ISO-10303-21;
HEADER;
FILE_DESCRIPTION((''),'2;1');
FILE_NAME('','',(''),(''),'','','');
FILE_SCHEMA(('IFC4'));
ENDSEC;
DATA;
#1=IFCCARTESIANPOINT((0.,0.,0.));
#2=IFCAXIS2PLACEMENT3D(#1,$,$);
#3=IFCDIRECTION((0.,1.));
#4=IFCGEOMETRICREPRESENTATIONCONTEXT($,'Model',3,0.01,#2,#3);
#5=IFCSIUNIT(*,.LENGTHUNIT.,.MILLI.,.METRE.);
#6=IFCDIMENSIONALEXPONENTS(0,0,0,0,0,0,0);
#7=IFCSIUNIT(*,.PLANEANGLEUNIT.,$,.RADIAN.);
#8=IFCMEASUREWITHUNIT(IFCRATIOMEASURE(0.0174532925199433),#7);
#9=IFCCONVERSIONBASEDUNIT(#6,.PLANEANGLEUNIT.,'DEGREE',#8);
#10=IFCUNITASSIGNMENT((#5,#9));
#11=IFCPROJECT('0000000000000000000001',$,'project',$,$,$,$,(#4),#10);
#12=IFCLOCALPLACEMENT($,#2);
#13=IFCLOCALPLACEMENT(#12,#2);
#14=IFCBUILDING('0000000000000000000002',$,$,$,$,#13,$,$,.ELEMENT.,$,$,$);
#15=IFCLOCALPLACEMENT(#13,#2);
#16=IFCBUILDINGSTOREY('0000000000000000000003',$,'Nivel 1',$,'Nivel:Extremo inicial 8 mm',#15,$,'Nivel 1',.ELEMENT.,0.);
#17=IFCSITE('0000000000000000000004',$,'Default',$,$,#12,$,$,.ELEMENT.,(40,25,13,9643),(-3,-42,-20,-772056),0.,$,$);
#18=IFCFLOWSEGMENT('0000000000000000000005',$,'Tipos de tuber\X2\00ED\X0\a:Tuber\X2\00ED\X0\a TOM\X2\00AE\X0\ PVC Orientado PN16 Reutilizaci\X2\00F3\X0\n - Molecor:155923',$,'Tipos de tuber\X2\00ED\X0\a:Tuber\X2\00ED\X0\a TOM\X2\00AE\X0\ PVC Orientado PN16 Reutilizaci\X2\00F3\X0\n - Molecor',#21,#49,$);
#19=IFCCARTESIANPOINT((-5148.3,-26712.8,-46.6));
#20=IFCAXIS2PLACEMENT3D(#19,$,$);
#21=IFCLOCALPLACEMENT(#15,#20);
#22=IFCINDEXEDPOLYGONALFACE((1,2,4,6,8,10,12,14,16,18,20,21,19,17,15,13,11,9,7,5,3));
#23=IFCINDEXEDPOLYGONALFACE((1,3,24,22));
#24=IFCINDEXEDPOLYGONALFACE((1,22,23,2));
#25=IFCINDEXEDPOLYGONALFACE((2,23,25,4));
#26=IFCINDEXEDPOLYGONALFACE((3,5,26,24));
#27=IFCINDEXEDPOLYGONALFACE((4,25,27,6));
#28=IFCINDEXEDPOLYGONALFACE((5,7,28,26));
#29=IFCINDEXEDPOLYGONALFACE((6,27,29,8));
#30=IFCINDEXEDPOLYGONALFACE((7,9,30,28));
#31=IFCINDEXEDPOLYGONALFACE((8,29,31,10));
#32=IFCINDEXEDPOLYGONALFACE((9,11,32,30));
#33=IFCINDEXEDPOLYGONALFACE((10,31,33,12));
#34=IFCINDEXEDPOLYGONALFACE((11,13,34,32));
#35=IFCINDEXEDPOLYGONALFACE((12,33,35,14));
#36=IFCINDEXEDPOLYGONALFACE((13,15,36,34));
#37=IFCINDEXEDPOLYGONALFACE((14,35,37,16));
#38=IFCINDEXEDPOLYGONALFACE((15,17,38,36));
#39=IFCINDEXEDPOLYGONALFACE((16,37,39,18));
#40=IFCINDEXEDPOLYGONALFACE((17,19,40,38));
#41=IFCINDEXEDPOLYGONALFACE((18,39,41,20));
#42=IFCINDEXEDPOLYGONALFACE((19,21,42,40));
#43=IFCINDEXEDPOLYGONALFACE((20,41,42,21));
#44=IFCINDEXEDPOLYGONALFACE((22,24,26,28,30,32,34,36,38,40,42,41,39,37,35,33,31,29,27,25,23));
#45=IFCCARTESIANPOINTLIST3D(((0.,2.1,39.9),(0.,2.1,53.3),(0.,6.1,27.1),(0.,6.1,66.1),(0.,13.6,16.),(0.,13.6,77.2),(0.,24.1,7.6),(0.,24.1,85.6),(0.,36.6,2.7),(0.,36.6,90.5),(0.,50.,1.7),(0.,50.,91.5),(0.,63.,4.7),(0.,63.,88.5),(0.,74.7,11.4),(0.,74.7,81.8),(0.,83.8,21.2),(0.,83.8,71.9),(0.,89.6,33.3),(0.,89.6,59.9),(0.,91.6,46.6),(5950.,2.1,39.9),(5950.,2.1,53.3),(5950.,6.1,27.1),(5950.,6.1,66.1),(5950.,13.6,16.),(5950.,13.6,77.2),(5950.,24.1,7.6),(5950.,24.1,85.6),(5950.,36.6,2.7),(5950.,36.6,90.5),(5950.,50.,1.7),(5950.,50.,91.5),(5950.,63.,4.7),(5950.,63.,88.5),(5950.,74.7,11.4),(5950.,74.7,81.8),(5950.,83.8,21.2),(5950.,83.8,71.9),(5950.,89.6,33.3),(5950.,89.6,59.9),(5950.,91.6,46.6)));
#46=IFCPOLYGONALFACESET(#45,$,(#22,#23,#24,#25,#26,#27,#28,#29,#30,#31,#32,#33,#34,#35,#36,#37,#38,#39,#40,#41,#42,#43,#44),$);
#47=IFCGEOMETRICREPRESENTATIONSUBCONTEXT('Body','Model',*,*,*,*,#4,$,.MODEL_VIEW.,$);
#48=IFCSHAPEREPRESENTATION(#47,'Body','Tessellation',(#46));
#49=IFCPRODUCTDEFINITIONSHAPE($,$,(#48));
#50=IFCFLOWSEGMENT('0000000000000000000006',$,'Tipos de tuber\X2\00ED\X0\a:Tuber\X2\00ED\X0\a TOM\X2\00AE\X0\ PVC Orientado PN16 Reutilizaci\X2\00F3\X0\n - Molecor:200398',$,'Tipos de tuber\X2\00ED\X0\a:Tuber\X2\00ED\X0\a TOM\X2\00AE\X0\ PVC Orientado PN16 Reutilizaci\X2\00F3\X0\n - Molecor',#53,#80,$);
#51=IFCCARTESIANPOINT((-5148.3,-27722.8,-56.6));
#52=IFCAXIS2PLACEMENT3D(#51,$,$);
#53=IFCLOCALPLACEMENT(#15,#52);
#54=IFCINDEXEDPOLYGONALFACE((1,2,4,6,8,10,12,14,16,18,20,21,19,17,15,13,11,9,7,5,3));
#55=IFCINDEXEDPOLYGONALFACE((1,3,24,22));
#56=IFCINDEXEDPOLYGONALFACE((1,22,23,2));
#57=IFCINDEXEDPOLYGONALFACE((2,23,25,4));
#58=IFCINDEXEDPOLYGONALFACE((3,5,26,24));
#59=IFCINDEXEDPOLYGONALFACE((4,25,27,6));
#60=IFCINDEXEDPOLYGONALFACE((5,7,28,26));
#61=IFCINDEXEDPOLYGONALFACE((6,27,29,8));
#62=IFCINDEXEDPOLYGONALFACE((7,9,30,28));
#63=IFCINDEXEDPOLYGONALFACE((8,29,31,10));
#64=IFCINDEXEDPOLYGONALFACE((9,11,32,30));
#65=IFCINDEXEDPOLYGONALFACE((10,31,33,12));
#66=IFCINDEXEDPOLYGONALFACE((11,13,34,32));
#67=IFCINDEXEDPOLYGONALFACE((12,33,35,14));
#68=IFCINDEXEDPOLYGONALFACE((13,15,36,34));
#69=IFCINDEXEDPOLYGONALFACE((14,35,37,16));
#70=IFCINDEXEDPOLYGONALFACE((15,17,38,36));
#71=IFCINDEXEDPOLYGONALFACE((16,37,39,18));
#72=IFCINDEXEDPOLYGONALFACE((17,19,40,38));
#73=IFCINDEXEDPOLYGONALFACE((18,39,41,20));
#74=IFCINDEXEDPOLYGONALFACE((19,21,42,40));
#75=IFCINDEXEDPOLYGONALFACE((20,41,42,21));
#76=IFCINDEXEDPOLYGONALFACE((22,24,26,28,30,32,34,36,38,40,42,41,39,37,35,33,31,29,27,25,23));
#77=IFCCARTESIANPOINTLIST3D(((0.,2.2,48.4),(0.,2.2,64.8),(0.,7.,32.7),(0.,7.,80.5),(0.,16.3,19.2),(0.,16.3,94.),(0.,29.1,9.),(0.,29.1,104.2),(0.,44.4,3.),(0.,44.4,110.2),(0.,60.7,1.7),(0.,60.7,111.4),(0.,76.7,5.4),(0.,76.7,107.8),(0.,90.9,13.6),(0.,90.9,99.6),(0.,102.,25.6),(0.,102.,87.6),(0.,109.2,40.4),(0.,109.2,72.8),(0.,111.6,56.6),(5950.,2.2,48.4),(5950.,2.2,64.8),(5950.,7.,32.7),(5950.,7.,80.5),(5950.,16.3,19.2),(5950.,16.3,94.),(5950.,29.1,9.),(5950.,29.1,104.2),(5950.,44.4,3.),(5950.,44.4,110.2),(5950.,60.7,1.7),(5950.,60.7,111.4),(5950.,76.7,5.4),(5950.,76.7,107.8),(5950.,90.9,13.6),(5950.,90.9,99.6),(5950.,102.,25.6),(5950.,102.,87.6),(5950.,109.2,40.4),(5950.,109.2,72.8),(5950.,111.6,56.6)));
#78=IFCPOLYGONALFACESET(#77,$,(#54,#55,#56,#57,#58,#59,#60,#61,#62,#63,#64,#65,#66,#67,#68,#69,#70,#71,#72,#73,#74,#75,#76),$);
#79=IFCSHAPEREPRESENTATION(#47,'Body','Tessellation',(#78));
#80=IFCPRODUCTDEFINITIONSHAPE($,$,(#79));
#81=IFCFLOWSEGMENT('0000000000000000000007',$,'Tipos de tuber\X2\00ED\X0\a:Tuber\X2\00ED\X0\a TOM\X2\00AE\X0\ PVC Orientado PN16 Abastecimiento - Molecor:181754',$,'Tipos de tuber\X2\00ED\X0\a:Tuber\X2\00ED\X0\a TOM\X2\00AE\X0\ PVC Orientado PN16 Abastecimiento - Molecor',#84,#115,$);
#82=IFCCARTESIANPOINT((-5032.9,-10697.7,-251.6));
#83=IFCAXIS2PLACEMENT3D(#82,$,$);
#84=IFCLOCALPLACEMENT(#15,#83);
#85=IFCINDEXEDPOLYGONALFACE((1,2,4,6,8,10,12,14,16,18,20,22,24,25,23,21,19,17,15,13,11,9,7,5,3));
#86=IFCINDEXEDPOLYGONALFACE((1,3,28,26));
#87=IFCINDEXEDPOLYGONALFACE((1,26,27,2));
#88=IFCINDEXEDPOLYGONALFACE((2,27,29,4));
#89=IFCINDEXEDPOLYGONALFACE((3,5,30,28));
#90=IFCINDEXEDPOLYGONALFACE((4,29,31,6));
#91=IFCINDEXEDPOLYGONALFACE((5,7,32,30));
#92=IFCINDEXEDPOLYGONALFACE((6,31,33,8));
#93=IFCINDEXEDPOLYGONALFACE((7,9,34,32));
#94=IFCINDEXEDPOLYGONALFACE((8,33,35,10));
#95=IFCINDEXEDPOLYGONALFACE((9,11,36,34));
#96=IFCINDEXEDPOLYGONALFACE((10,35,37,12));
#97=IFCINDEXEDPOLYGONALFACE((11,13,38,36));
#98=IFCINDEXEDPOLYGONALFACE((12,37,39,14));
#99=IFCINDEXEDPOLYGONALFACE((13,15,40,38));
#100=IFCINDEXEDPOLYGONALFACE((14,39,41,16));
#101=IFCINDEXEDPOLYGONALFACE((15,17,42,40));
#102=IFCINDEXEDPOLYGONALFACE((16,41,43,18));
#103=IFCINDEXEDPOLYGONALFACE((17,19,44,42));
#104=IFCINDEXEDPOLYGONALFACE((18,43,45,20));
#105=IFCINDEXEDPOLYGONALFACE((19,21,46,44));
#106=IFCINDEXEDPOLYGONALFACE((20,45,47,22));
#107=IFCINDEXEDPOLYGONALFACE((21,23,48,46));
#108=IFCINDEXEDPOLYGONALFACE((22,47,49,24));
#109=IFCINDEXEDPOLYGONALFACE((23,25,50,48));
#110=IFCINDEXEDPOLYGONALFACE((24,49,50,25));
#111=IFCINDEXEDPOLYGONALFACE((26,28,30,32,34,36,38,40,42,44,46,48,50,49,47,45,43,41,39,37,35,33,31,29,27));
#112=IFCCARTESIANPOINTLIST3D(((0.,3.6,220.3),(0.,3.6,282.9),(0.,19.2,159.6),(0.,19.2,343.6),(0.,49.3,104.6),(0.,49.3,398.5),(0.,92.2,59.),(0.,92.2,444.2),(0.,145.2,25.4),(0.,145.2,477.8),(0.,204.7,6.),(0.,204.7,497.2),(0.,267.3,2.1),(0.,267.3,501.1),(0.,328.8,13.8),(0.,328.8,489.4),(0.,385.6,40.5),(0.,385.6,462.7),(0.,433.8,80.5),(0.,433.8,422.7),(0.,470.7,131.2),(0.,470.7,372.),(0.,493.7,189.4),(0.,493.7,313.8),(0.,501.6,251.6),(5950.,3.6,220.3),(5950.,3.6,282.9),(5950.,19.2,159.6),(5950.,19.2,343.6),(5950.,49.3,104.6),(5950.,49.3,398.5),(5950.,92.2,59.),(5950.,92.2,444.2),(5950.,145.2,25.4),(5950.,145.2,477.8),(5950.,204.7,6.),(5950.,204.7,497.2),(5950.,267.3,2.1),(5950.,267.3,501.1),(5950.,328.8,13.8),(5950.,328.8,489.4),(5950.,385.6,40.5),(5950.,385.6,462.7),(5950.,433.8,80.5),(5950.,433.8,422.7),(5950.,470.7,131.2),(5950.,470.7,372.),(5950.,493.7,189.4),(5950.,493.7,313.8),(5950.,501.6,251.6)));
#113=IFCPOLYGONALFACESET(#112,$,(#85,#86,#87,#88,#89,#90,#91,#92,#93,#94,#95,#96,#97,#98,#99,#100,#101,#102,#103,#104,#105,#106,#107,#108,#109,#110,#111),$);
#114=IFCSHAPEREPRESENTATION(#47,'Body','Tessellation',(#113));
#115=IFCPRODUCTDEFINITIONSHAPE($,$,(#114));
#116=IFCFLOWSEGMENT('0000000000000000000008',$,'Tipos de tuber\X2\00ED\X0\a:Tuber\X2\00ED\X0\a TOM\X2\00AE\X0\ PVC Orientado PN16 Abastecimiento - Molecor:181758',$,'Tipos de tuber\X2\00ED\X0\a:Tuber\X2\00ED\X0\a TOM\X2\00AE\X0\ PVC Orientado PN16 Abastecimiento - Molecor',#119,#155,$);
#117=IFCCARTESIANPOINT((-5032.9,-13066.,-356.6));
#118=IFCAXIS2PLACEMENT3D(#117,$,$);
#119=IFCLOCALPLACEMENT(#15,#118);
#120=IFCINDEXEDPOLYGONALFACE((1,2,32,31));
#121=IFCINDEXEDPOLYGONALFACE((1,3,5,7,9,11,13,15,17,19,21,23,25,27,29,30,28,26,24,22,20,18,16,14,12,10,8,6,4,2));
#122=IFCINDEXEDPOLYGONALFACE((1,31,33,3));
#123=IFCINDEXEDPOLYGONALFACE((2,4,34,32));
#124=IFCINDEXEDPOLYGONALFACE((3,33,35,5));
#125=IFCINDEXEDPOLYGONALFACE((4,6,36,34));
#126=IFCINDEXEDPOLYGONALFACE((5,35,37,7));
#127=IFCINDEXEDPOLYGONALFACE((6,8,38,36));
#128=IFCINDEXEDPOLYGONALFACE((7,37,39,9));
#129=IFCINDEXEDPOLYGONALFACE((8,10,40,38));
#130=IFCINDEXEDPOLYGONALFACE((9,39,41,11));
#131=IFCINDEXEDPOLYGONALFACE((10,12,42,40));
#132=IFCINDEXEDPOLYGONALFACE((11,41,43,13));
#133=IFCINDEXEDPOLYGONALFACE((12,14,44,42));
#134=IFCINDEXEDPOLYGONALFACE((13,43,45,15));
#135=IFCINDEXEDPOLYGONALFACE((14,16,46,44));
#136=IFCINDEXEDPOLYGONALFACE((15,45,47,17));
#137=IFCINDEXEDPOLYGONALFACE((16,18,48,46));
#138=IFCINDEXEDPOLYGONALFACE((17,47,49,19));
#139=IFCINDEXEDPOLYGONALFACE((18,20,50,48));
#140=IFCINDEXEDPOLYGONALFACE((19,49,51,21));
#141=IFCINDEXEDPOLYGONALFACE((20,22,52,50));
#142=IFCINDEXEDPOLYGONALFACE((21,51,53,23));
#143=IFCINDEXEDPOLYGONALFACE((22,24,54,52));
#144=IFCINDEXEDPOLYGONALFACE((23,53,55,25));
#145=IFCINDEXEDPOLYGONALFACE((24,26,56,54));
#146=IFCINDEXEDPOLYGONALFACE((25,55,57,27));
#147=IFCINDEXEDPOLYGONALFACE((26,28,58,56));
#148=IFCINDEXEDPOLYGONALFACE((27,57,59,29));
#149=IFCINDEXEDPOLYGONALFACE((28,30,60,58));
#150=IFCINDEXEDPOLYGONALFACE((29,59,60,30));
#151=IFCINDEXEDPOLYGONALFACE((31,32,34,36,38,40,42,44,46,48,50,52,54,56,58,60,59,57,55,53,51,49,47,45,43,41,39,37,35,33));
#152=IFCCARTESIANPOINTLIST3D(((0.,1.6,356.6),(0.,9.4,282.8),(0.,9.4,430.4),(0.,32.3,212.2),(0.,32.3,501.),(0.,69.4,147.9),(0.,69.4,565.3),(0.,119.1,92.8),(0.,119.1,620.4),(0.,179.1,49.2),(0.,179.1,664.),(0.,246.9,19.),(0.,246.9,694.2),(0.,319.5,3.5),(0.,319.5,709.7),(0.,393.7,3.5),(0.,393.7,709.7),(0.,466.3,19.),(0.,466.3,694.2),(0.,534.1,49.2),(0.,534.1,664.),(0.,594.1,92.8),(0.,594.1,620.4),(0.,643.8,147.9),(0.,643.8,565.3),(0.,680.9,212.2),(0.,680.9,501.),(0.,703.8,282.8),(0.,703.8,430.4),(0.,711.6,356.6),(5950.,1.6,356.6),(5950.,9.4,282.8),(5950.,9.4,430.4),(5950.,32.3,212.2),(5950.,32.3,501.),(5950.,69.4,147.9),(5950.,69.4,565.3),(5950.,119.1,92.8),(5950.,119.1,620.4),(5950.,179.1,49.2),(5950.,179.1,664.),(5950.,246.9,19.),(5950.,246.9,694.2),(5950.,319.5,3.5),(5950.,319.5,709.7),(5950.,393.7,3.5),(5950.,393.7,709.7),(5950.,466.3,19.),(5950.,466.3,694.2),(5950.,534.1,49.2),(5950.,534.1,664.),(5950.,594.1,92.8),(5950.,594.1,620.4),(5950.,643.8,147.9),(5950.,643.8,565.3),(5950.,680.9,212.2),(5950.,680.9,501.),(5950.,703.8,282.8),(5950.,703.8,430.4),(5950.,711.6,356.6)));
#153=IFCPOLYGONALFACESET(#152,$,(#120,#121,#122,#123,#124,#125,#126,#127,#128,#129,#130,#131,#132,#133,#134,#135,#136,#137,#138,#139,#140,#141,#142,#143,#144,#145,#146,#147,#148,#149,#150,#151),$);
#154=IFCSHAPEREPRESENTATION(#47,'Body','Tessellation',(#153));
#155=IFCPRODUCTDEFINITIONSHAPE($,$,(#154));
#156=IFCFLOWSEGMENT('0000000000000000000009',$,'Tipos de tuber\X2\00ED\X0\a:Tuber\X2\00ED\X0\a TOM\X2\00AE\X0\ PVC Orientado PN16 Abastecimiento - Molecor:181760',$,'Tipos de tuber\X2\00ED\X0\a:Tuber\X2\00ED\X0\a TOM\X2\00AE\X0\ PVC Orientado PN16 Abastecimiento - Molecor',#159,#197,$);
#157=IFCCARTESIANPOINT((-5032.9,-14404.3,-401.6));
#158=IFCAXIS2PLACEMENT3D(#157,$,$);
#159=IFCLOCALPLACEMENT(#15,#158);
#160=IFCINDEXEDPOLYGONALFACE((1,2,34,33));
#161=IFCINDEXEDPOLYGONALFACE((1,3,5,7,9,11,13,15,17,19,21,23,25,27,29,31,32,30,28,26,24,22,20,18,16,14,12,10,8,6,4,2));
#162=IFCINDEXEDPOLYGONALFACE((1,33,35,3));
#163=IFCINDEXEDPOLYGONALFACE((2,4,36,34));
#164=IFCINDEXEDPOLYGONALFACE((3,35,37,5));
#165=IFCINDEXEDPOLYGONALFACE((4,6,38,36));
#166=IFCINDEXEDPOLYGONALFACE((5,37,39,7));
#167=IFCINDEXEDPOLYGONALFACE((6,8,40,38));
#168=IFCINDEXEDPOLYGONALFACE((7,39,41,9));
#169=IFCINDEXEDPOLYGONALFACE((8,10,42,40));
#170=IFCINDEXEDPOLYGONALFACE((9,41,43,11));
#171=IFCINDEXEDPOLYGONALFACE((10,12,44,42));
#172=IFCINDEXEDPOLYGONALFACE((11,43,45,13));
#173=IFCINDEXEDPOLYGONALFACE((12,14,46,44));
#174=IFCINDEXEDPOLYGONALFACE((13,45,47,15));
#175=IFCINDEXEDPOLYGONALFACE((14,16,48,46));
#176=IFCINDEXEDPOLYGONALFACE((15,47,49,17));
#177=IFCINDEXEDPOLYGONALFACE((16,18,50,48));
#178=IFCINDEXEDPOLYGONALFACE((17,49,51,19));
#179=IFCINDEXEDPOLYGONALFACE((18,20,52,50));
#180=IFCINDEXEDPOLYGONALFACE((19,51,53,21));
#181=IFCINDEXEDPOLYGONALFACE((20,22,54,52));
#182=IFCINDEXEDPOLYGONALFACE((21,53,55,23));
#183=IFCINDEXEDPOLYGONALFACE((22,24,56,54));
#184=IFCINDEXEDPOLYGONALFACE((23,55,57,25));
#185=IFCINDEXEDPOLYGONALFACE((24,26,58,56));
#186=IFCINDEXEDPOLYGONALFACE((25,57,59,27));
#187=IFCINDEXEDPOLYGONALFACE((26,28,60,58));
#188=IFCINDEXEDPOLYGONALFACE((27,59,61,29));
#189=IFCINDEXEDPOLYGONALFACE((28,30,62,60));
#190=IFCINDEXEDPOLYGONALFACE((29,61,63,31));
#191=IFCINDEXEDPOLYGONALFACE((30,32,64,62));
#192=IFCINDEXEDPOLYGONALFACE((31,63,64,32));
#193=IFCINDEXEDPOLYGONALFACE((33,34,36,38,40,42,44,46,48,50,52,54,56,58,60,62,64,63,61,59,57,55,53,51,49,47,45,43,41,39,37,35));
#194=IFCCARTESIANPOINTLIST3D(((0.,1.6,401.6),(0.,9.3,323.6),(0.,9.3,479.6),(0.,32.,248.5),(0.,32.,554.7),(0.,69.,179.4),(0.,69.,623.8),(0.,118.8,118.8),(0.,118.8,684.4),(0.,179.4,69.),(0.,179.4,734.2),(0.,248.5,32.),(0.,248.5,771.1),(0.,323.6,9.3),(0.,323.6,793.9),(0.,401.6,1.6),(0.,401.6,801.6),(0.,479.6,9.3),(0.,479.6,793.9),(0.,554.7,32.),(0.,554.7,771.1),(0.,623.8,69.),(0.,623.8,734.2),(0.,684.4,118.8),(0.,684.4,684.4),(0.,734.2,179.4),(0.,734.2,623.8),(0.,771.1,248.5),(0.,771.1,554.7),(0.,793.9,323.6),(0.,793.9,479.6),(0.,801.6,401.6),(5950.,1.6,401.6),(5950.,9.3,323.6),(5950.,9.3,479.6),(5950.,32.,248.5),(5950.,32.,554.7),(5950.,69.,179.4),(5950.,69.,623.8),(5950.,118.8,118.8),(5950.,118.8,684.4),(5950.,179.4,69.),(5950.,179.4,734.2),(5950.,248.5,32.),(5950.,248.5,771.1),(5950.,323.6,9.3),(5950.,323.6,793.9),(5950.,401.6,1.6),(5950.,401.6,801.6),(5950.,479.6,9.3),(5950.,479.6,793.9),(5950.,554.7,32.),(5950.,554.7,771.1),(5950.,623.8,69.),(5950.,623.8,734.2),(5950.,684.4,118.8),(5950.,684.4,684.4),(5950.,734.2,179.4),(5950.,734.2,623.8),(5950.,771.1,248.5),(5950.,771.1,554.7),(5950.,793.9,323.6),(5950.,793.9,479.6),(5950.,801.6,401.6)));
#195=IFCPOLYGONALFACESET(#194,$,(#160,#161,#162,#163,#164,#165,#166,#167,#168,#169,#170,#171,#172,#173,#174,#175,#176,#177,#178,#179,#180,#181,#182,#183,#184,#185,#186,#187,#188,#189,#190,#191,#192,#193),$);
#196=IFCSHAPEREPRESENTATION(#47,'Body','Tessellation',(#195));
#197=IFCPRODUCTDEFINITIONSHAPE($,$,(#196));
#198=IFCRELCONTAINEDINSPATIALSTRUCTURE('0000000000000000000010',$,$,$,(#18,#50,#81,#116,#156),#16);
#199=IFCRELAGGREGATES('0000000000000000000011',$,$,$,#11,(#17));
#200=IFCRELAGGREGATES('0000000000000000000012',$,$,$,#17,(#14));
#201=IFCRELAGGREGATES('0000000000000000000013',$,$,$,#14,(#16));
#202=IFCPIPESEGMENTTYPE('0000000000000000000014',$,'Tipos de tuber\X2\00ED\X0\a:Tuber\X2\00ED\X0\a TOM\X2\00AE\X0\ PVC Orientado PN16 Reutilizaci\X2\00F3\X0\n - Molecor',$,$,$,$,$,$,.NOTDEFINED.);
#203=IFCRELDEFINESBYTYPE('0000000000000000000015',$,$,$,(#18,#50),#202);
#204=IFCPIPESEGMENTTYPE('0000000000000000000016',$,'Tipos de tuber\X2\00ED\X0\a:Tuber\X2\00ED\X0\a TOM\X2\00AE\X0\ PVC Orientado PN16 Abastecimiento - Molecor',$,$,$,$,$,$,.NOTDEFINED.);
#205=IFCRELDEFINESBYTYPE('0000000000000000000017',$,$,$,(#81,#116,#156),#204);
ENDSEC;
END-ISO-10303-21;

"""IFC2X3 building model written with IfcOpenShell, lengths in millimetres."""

from ifc_helpers import new_model, entity, si_unit, converted_unit, direction, frame, frame_2d, origin, place, context, subcontext, project, spatial, circle, extrude, type_object, element, save


model = new_model("IFC2X3")

# Units and contexts
model_context = context("Model", 3, precision=0.01, world=origin(), true_north=direction((0.0, 1.0)))
body_context = subcontext(model_context, "Body", "Model", "MODEL_VIEW")
ifc_project = project(units=[si_unit("LENGTHUNIT", "METRE", prefix="MILLI"), converted_unit("PLANEANGLEUNIT", "DEGREE", entity("IfcRatioMeasure", 0.0174532925199433), si_unit("PLANEANGLEUNIT", "RADIAN"), dimensions=[0, 0, 0, 0, 0, 0, 0])], contexts=[model_context])

# Site, building, storey
site_placement = place(None, origin())
site = spatial("IfcSite", under=ifc_project, at=site_placement, Name="Default", CompositionType="ELEMENT", RefLatitude=(40, 25, 13, 9643), RefLongitude=(-3, -42, -20, -772056), RefElevation=0.0)
building_placement = place(site_placement, origin())
building = spatial("IfcBuilding", under=site, at=building_placement, CompositionType="ELEMENT")
storey_placement = place(building_placement, origin())
storey = spatial("IfcBuildingStorey", under=building, at=storey_placement, Name="Nivel 1", ObjectType="Nivel:Extremo inicial 8 mm", LongName="Nivel 1", CompositionType="ELEMENT", Elevation=0.0)

# Flow segments
pipe_segment_type_1 = type_object("IfcPipeSegmentType", Name="Tipos de tubería:Tubería TOM® PVC Orientado PN16 Reutilización - Molecor", PredefinedType="NOTDEFINED")
flow_segment_1_placement = place(storey_placement, frame((-5148.3, -26712.8, -46.6)))
element("IfcFlowSegment", 1, at=flow_segment_1_placement, inside=storey, type_object=pipe_segment_type_1, Name="Tipos de tubería:Tubería TOM® PVC Orientado PN16 Reutilización - Molecor:155923", ObjectType="Tipos de tubería:Tubería TOM® PVC Orientado PN16 Reutilización - Molecor", context=body_context, shape_type="SweptSolid", body=[
    extrude(circle(Radius=45.0, at=frame_2d((0.0, 0.0), x_axis=(1.0, 0.0))), frame((0.0, 46.6, 46.6), z_axis=(1.0, 0.0, 0.0), x_axis=(0.0, 1.0, 0.0)), (0.0, 0.0, 1.0), 5950.0),
])
flow_segment_2_placement = place(storey_placement, frame((-5148.3, -27722.8, -56.6)))
element("IfcFlowSegment", 2, at=flow_segment_2_placement, inside=storey, type_object=pipe_segment_type_1, Name="Tipos de tubería:Tubería TOM® PVC Orientado PN16 Reutilización - Molecor:200398", ObjectType="Tipos de tubería:Tubería TOM® PVC Orientado PN16 Reutilización - Molecor", context=body_context, shape_type="SweptSolid", body=[
    extrude(circle(Radius=55.0, at=frame_2d((0.0, 0.0), x_axis=(1.0, 0.0))), frame((0.0, 56.6, 56.6), z_axis=(1.0, 0.0, 0.0), x_axis=(0.0, 1.0, 0.0)), (0.0, 0.0, 1.0), 5950.0),
])
pipe_segment_type_2 = type_object("IfcPipeSegmentType", Name="Tipos de tubería:Tubería TOM® PVC Orientado PN16 Abastecimiento - Molecor", PredefinedType="NOTDEFINED")
flow_segment_3_placement = place(storey_placement, frame((-5032.9, -10697.7, -251.6)))
element("IfcFlowSegment", 3, at=flow_segment_3_placement, inside=storey, type_object=pipe_segment_type_2, Name="Tipos de tubería:Tubería TOM® PVC Orientado PN16 Abastecimiento - Molecor:181754", ObjectType="Tipos de tubería:Tubería TOM® PVC Orientado PN16 Abastecimiento - Molecor", context=body_context, shape_type="SweptSolid", body=[
    extrude(circle(Radius=250.0, at=frame_2d((0.0, 0.0), x_axis=(1.0, 0.0))), frame((0.0, 251.6, 251.6), z_axis=(1.0, 0.0, 0.0), x_axis=(0.0, 1.0, 0.0)), (0.0, 0.0, 1.0), 5950.0),
])
flow_segment_4_placement = place(storey_placement, frame((-5032.9, -13066.0, -356.6)))
element("IfcFlowSegment", 4, at=flow_segment_4_placement, inside=storey, type_object=pipe_segment_type_2, Name="Tipos de tubería:Tubería TOM® PVC Orientado PN16 Abastecimiento - Molecor:181758", ObjectType="Tipos de tubería:Tubería TOM® PVC Orientado PN16 Abastecimiento - Molecor", context=body_context, shape_type="SweptSolid", body=[
    extrude(circle(Radius=355.0, at=frame_2d((0.0, 0.0), x_axis=(1.0, 0.0))), frame((0.0, 356.6, 356.6), z_axis=(1.0, 0.0, 0.0), x_axis=(0.0, 1.0, 0.0)), (0.0, 0.0, 1.0), 5950.0),
])
flow_segment_5_placement = place(storey_placement, frame((-5032.9, -14404.3, -401.6)))
element("IfcFlowSegment", 5, at=flow_segment_5_placement, inside=storey, type_object=pipe_segment_type_2, Name="Tipos de tubería:Tubería TOM® PVC Orientado PN16 Abastecimiento - Molecor:181760", ObjectType="Tipos de tubería:Tubería TOM® PVC Orientado PN16 Abastecimiento - Molecor", context=body_context, shape_type="SweptSolid", body=[
    extrude(circle(Radius=400.0, at=frame_2d((0.0, 0.0), x_axis=(1.0, 0.0))), frame((0.0, 401.6, 401.6), z_axis=(1.0, 0.0, 0.0), x_axis=(0.0, 1.0, 0.0)), (0.0, 0.0, 1.0), 5950.0),
])

save(model, "model.ifc")
